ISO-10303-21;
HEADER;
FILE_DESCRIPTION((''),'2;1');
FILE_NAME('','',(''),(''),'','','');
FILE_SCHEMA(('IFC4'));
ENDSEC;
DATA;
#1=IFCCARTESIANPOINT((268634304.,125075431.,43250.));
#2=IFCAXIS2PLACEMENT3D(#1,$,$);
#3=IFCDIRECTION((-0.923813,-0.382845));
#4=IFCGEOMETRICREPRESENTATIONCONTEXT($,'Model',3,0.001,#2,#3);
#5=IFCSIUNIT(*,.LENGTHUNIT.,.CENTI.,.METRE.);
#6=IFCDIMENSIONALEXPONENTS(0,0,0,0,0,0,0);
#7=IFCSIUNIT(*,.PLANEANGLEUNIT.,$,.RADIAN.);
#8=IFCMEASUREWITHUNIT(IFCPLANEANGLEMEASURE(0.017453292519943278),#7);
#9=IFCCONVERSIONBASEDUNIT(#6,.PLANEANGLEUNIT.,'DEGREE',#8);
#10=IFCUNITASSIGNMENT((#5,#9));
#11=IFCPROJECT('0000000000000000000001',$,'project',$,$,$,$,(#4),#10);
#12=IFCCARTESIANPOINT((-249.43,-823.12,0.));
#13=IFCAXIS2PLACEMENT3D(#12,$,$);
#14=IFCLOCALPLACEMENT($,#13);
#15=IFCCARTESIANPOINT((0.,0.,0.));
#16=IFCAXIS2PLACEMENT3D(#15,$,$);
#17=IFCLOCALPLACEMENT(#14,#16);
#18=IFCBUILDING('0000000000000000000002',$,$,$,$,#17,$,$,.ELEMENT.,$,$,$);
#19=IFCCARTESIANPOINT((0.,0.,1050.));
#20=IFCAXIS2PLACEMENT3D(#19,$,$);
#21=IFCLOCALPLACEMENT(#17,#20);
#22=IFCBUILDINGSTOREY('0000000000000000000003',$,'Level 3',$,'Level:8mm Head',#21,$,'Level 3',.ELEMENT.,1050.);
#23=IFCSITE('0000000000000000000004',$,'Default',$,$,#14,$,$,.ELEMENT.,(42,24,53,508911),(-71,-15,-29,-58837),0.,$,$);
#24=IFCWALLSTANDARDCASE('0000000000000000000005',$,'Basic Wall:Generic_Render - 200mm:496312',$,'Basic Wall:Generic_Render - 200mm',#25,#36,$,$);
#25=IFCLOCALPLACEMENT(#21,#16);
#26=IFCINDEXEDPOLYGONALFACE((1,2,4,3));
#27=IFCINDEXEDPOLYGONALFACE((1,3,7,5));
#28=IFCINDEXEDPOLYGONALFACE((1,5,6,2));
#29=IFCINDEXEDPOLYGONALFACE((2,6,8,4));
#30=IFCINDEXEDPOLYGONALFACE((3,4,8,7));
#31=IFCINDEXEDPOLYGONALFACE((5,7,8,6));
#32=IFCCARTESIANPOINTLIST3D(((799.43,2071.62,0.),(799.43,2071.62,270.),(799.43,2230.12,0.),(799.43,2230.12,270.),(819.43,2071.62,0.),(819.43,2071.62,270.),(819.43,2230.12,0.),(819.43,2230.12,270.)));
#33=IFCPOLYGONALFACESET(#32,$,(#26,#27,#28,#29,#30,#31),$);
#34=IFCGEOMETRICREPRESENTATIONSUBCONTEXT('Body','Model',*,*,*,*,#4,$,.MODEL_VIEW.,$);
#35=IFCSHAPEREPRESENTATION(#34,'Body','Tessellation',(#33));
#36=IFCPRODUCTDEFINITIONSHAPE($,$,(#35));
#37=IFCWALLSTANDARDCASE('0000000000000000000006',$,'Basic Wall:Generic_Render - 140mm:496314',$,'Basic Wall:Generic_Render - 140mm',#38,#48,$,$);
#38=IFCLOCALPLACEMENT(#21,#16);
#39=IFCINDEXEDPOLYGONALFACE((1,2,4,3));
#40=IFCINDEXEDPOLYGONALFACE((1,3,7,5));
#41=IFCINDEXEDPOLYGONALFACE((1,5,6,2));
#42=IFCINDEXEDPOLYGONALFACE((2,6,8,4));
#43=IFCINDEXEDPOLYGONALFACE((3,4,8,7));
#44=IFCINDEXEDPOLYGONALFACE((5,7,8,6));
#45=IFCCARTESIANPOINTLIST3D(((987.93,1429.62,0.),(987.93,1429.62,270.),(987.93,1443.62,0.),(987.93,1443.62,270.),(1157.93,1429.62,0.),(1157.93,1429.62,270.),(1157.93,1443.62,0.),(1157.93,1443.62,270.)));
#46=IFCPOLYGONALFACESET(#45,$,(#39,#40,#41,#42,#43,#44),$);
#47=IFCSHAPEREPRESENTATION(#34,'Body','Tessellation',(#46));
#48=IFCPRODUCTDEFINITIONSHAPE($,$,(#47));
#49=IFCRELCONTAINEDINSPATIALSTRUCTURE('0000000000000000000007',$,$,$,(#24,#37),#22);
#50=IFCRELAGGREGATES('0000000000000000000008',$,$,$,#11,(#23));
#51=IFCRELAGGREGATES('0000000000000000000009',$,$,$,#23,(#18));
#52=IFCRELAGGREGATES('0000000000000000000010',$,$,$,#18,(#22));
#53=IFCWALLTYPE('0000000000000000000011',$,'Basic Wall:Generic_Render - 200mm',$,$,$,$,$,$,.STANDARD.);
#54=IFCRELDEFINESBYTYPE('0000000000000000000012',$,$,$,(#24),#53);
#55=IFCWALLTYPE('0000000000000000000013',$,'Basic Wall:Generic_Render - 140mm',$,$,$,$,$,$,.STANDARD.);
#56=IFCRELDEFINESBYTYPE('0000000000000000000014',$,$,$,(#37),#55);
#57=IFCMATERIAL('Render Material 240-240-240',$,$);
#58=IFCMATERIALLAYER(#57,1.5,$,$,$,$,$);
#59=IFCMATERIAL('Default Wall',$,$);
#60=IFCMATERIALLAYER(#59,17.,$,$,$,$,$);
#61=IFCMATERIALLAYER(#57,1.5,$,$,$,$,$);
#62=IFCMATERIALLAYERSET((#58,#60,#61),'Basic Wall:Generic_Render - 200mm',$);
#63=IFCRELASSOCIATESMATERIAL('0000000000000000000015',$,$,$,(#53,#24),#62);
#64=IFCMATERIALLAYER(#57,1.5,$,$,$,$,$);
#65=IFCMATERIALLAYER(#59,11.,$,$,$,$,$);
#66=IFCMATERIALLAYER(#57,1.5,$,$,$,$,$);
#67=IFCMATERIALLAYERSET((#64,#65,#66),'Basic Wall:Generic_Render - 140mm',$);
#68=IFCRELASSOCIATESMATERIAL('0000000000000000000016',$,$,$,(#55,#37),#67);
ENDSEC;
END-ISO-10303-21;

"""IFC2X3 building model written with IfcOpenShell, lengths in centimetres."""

from ifc_helpers import new_model, entity, si_unit, converted_unit, direction, frame, frame_2d, origin, place, context, subcontext, project, spatial, rectangle, extrude, material, layer, layer_set, layer_usage, type_object, element, save


model = new_model("IFC2X3")

# Units and contexts
model_context = context("Model", 3, precision=0.001, world=frame((268634304.0, 125075431.0, 43250.0)), true_north=direction((-0.923813, -0.382845)))
body_context = subcontext(model_context, "Body", "Model", "MODEL_VIEW")
ifc_project = project(units=[si_unit("LENGTHUNIT", "METRE", prefix="CENTI"), converted_unit("PLANEANGLEUNIT", "DEGREE", entity("IfcPlaneAngleMeasure", 0.017453292519943278), si_unit("PLANEANGLEUNIT", "RADIAN"), dimensions=[0, 0, 0, 0, 0, 0, 0])], contexts=[model_context])

# Site, building, storey
site_placement = place(None, frame((-249.43, -823.12, 0.0)))
site = spatial("IfcSite", under=ifc_project, at=site_placement, Name="Default", CompositionType="ELEMENT", RefLatitude=(42, 24, 53, 508911), RefLongitude=(-71, -15, -29, -58837), RefElevation=0.0)
building_placement = place(site_placement, origin())
building = spatial("IfcBuilding", under=site, at=building_placement, CompositionType="ELEMENT")
storey_placement = place(building_placement, frame((0.0, 0.0, 1050.0)))
storey = spatial("IfcBuildingStorey", under=building, at=storey_placement, Name="Level 3", ObjectType="Level:8mm Head", LongName="Level 3", CompositionType="ELEMENT", Elevation=1050.0)

# Shared definitions
ifc_material_1 = material(Name="Render Material 240-240-240")

# Shared definitions
ifc_layer_1 = layer(ifc_material_1, 1.5)
ifc_material_2 = material(Name="Default Wall")
ifc_layer_2 = layer(ifc_material_2, 17.0)
ifc_layer_3 = layer(ifc_material_1, 1.5)
ifc_layer_set_1 = layer_set([ifc_layer_1, ifc_layer_2, ifc_layer_3], Name="Basic Wall:Generic_Render - 200mm")
wall_type_1 = type_object("IfcWallType", Name="Basic Wall:Generic_Render - 200mm", PredefinedType="STANDARD", material=ifc_layer_set_1)

# Walls
ifc_layer_usage_1 = layer_usage(ifc_layer_set_1, "AXIS2", "NEGATIVE", 10.0)
wall_1_placement = place(storey_placement, frame((809.43, 2071.62, 0.0), z_axis=(0.0, 0.0, 1.0), x_axis=(0.0, 1.0, 0.0)))
element("IfcWallStandardCase", 1, at=wall_1_placement, inside=storey, type_object=wall_type_1, material=ifc_layer_usage_1, Name="Basic Wall:Generic_Render - 200mm:496312", ObjectType="Basic Wall:Generic_Render - 200mm", context=body_context, shape_type="SweptSolid", body=[
    extrude(rectangle(XDim=158.5, YDim=20.0, at=frame_2d((79.25, 0.0), x_axis=(-1.0, 0.0))), origin(), (0.0, 0.0, 1.0), 270.0),
])
ifc_layer_4 = layer(ifc_material_1, 1.5)
ifc_layer_5 = layer(ifc_material_2, 11.0)
ifc_layer_6 = layer(ifc_material_1, 1.5)
ifc_layer_set_2 = layer_set([ifc_layer_4, ifc_layer_5, ifc_layer_6], Name="Basic Wall:Generic_Render - 140mm")
ifc_layer_usage_2 = layer_usage(ifc_layer_set_2, "AXIS2", "NEGATIVE", 7.0)
wall_type_2 = type_object("IfcWallType", Name="Basic Wall:Generic_Render - 140mm", PredefinedType="STANDARD", material=ifc_layer_set_2)
wall_2_placement = place(storey_placement, frame((1157.93, 1436.62, 0.0), z_axis=(0.0, 0.0, 1.0), x_axis=(-1.0, 0.0, 0.0)))
element("IfcWallStandardCase", 2, at=wall_2_placement, inside=storey, type_object=wall_type_2, material=ifc_layer_usage_2, Name="Basic Wall:Generic_Render - 140mm:496314", ObjectType="Basic Wall:Generic_Render - 140mm", context=body_context, shape_type="SweptSolid", body=[
    extrude(rectangle(XDim=170.0, YDim=14.0, at=frame_2d((85.0, 0.0), x_axis=(-1.0, 0.0))), origin(), (0.0, 0.0, 1.0), 270.0),
])

save(model, "model.ifc")
